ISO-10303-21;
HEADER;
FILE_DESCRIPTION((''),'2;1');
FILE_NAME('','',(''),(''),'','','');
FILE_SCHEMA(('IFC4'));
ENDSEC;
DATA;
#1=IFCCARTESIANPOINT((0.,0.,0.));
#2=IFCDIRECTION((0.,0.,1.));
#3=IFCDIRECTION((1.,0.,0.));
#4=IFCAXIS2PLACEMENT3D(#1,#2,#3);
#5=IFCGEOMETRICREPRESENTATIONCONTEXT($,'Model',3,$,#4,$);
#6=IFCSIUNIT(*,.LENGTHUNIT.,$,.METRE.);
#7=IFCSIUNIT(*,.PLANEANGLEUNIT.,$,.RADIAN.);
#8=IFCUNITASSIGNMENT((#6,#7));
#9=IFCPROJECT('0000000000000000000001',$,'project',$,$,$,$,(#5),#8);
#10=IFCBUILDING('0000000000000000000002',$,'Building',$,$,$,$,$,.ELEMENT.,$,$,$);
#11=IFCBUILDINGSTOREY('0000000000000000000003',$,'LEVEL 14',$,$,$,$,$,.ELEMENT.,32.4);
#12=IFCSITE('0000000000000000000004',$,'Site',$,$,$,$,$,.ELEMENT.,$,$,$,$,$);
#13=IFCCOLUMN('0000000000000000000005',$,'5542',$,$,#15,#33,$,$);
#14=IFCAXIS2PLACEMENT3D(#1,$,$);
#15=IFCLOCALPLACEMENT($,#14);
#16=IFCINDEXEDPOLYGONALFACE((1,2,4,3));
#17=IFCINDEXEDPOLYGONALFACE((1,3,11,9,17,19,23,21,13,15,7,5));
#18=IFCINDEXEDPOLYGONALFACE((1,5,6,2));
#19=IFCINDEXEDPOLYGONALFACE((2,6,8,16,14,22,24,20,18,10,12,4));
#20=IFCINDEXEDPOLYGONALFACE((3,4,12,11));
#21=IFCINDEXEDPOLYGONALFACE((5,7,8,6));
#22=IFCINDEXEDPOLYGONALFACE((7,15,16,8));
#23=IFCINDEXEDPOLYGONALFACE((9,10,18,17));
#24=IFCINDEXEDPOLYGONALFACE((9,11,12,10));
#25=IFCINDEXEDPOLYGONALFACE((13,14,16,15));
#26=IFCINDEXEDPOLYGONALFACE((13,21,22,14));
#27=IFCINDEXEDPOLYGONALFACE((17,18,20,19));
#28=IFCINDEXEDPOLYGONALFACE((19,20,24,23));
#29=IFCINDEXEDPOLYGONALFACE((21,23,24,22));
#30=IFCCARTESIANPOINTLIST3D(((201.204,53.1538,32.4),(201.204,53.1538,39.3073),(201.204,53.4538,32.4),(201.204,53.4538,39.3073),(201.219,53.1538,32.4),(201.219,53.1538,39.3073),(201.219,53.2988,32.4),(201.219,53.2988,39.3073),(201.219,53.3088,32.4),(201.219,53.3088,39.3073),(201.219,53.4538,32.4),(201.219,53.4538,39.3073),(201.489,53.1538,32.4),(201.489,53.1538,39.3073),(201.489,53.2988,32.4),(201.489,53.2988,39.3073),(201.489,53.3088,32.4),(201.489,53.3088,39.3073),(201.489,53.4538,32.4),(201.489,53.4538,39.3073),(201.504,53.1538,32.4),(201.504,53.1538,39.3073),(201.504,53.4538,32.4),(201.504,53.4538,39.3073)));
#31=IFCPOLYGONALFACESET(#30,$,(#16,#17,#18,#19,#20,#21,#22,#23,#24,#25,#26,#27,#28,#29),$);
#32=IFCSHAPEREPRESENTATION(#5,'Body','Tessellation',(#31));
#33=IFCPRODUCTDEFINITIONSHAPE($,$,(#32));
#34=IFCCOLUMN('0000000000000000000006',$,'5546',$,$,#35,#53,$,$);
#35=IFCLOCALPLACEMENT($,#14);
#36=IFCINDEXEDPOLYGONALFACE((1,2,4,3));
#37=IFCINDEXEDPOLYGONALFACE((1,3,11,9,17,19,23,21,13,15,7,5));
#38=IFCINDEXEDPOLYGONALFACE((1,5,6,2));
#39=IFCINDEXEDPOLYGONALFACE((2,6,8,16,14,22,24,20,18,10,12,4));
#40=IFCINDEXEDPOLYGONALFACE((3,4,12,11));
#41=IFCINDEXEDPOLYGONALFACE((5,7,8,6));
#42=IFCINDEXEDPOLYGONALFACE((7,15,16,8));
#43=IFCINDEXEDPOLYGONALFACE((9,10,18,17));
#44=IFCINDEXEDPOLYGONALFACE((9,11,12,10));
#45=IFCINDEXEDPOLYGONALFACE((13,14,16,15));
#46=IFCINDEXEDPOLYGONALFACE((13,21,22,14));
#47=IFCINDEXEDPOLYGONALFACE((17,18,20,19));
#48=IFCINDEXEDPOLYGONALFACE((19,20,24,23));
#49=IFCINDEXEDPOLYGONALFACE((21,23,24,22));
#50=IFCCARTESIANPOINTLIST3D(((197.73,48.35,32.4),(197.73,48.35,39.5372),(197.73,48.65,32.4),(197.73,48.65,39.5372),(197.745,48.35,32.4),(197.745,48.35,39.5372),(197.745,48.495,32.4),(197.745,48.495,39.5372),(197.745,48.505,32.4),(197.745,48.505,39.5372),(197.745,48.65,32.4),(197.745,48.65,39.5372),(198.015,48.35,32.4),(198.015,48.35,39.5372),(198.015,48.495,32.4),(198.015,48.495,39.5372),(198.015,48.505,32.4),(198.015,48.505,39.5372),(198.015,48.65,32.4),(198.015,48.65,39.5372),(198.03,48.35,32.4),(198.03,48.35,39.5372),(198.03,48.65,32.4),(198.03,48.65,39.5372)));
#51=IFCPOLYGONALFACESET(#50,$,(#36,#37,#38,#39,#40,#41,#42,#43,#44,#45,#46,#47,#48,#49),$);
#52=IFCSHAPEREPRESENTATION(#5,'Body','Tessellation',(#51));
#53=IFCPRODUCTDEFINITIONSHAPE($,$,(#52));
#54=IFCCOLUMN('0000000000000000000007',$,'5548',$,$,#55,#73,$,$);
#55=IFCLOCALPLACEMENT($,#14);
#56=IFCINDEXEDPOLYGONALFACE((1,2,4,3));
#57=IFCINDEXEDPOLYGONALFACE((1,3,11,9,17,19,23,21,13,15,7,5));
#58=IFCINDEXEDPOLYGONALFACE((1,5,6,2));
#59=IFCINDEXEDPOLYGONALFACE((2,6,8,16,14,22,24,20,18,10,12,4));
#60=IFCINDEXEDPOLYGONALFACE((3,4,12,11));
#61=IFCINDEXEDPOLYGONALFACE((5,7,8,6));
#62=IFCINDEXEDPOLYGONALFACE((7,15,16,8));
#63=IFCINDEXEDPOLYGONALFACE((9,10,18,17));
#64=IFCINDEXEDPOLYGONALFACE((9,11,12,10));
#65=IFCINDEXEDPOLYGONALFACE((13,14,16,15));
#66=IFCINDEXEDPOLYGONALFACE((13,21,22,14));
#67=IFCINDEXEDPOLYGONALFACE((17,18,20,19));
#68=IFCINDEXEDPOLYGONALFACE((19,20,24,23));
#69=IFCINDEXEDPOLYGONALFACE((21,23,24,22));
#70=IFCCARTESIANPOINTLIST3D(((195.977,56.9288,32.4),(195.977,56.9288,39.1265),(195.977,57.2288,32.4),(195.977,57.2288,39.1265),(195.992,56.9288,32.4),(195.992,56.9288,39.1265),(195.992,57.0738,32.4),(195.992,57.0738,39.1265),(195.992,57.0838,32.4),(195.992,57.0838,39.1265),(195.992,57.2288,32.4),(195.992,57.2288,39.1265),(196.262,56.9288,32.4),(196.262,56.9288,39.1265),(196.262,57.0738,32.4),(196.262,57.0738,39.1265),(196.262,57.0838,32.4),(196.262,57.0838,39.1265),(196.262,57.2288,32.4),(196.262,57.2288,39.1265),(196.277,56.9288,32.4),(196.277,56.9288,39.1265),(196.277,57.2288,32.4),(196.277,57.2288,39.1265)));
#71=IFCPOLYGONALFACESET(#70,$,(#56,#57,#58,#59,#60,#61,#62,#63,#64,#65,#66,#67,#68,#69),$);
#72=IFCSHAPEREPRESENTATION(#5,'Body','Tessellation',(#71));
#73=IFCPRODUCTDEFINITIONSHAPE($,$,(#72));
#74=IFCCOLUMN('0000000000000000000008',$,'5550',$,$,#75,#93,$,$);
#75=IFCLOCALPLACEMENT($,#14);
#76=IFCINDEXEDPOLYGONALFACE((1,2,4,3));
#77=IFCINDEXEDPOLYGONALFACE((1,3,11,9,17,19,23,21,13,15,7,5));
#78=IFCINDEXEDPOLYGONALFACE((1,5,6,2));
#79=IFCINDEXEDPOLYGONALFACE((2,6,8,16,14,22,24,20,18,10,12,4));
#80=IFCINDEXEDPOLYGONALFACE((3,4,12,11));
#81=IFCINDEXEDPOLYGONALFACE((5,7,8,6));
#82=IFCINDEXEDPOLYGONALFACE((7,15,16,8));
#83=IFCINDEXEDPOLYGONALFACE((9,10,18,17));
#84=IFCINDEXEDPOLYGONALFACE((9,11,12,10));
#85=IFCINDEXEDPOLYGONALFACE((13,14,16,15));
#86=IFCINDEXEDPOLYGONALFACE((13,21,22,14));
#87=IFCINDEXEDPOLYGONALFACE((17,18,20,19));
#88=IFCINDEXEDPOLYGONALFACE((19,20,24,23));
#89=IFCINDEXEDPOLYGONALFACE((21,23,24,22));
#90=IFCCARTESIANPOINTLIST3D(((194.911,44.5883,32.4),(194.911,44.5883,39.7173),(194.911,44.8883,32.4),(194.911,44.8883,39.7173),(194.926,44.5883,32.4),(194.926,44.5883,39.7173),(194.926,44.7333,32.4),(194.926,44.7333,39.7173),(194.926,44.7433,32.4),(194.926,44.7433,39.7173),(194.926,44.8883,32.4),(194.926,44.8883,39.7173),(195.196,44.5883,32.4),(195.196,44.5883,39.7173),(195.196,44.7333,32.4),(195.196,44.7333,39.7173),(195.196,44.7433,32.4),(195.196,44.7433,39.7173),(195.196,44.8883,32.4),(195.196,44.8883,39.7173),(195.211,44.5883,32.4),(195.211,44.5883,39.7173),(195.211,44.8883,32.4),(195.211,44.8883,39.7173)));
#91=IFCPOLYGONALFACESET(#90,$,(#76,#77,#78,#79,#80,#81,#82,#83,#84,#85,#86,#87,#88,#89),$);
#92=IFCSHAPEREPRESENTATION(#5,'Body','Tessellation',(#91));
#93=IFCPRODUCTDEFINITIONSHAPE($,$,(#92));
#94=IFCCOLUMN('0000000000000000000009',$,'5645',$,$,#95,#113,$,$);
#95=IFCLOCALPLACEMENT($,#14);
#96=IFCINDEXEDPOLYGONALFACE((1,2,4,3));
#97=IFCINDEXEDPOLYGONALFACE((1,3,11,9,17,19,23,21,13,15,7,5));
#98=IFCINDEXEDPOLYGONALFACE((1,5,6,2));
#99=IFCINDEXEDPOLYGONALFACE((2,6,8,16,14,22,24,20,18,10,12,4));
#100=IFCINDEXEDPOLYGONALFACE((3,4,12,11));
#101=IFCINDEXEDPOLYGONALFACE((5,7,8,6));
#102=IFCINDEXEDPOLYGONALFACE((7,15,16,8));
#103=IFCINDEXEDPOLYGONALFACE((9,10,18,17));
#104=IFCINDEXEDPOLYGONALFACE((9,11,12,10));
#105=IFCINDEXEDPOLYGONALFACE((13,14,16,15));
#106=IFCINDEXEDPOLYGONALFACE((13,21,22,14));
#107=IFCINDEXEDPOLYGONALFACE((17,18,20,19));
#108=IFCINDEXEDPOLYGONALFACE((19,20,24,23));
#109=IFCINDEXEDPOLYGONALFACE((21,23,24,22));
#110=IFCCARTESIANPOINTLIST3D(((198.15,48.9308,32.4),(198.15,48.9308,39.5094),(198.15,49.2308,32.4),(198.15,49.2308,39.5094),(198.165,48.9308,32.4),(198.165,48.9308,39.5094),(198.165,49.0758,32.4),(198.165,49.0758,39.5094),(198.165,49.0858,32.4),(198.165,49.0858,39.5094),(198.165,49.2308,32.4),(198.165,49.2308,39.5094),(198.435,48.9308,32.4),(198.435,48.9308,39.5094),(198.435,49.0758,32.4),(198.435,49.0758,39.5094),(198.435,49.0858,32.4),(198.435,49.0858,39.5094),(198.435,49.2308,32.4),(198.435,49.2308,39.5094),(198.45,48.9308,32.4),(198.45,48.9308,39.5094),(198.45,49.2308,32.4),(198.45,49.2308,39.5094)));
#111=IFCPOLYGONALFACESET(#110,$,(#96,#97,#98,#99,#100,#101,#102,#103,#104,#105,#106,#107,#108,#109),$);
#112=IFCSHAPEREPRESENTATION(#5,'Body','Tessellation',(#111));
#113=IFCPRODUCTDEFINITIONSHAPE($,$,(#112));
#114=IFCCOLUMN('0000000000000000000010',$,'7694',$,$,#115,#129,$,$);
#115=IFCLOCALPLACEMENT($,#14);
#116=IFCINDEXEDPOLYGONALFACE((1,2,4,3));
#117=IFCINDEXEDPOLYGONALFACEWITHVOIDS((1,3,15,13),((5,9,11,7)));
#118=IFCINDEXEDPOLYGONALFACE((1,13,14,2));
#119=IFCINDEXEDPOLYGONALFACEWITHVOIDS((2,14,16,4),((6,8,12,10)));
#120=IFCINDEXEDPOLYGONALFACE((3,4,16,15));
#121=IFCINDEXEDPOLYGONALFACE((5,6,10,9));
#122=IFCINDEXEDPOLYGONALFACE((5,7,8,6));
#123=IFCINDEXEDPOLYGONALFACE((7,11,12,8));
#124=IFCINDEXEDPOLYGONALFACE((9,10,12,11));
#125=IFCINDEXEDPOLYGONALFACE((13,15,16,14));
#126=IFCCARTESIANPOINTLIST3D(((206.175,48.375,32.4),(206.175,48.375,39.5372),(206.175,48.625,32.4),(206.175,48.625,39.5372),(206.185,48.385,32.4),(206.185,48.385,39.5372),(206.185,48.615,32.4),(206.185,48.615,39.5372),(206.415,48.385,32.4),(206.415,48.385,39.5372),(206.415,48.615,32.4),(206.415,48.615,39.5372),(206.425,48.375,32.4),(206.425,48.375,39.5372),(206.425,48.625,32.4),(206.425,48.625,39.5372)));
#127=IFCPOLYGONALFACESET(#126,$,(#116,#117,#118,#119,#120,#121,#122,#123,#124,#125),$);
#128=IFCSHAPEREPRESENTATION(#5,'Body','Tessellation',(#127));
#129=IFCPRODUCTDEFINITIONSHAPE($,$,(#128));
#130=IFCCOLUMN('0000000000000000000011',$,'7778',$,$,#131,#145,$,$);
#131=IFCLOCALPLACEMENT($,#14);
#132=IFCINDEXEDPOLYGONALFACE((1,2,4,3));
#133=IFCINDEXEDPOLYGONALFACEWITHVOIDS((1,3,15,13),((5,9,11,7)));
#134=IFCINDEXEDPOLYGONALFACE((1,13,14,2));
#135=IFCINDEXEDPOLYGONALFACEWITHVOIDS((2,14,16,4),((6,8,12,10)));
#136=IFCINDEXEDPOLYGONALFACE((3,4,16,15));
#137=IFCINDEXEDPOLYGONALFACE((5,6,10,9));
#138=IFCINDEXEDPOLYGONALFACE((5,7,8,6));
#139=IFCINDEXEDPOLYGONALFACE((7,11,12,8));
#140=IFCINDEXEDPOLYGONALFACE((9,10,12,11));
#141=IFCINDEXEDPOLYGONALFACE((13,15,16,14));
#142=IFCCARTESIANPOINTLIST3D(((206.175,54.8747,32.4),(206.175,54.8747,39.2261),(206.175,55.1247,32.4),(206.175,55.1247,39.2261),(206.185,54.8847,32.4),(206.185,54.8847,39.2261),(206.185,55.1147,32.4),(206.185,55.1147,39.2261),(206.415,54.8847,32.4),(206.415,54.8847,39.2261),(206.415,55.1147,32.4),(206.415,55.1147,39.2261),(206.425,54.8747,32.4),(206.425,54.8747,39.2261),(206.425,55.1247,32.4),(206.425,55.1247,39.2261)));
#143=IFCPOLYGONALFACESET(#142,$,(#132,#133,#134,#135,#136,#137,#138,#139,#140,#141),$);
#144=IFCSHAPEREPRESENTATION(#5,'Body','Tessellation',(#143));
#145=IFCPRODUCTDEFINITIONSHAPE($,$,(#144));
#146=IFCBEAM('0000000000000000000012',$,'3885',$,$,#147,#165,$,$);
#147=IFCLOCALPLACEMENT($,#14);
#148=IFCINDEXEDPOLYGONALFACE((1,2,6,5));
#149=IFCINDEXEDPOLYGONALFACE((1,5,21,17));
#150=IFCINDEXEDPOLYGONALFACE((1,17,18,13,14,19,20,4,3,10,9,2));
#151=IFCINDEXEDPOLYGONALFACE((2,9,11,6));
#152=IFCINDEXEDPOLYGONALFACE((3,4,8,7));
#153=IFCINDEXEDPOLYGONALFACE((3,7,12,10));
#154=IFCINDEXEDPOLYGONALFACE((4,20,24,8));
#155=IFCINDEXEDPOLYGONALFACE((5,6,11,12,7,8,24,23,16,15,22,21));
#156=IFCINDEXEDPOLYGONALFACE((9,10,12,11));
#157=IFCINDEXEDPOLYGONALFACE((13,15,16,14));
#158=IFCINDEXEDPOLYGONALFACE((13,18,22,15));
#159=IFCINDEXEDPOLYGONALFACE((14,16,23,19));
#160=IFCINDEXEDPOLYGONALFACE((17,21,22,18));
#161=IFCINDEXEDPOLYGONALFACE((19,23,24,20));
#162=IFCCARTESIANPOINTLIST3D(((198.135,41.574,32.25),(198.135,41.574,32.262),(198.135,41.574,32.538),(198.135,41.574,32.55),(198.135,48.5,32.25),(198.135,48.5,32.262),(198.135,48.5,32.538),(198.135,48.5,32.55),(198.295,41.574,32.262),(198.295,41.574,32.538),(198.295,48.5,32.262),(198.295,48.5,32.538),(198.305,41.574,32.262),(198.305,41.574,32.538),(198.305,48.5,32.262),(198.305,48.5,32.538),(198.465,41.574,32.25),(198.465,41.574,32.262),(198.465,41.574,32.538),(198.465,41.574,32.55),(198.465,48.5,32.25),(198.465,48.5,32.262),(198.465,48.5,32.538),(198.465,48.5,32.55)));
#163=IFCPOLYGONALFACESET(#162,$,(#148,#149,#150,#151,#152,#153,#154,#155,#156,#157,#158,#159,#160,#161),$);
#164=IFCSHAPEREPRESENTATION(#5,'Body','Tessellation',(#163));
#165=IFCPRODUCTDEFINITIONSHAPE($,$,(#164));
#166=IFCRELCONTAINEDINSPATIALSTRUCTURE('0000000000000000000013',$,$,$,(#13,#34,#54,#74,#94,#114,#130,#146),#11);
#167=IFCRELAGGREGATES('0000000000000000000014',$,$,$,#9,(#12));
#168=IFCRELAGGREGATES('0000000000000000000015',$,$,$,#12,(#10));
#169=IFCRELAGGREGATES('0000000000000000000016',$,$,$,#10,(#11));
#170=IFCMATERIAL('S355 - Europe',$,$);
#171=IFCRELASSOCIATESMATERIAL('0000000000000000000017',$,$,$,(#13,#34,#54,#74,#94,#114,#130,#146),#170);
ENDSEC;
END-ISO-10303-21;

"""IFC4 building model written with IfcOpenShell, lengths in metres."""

from ifc_helpers import new_model, si_unit, frame, origin_with_axes, origin_2d_with_axis, place, context, project, spatial, hollow_rectangle, i_section, extrude, material, material_profile, profile_set, profile_usage, element, save


model = new_model("IFC4")

# Units and contexts
model_context = context("Model", 3, world=origin_with_axes())
ifc_project = project(units=[si_unit("LENGTHUNIT", "METRE"), si_unit("PLANEANGLEUNIT", "RADIAN")], contexts=[model_context])

# Site, building, storey
site = spatial("IfcSite", under=ifc_project, Name="Site", CompositionType="ELEMENT")
building = spatial("IfcBuilding", under=site, Name="Building", CompositionType="ELEMENT")
storey = spatial("IfcBuildingStorey", under=building, Name="LEVEL 14", CompositionType="ELEMENT", Elevation=32.4)

# Columns
ifc_material = material(Name="S355 - Europe")
ifc_material_profile_1 = material_profile(ifc_material, i_section(OverallWidth=0.3, OverallDepth=0.3, WebThickness=0.01, FlangeThickness=0.015, at=origin_2d_with_axis()))
ifc_profile_set_1 = profile_set([ifc_material_profile_1])
ifc_profile_usage_1 = profile_usage(ifc_profile_set_1, cardinal=10)
column_1_placement = place(None, frame((201.354, 53.3038, 32.4), z_axis=(0.0, 0.0, 1.0), x_axis=(0.0, -1.0, 0.0)))
element("IfcColumn", 1, at=column_1_placement, inside=storey, material=ifc_profile_usage_1, Name="5542", context=model_context, shape_type="SweptSolid", body=[
    extrude(i_section(OverallWidth=0.3, OverallDepth=0.3, WebThickness=0.01, FlangeThickness=0.015, at=origin_2d_with_axis()), origin_with_axes(), (0.0, 0.0, 1.0), 6.9073),
])
ifc_material_profile_2 = material_profile(ifc_material, i_section(OverallWidth=0.3, OverallDepth=0.3, WebThickness=0.01, FlangeThickness=0.015, at=origin_2d_with_axis()))
ifc_profile_set_2 = profile_set([ifc_material_profile_2])
ifc_profile_usage_2 = profile_usage(ifc_profile_set_2, cardinal=10)
column_2_placement = place(None, frame((197.88, 48.5, 32.4), z_axis=(0.0, 0.0, 1.0), x_axis=(0.0, -1.0, 0.0)))
element("IfcColumn", 2, at=column_2_placement, inside=storey, material=ifc_profile_usage_2, Name="5546", context=model_context, shape_type="SweptSolid", body=[
    extrude(i_section(OverallWidth=0.3, OverallDepth=0.3, WebThickness=0.01, FlangeThickness=0.015, at=origin_2d_with_axis()), origin_with_axes(), (0.0, 0.0, 1.0), 7.1372),
])
ifc_material_profile_3 = material_profile(ifc_material, i_section(OverallWidth=0.3, OverallDepth=0.3, WebThickness=0.01, FlangeThickness=0.015, at=origin_2d_with_axis()))
ifc_profile_set_3 = profile_set([ifc_material_profile_3])
ifc_profile_usage_3 = profile_usage(ifc_profile_set_3, cardinal=10)
column_3_placement = place(None, frame((196.127, 57.0788, 32.4), z_axis=(0.0, 0.0, 1.0), x_axis=(0.0, -1.0, 0.0)))
element("IfcColumn", 3, at=column_3_placement, inside=storey, material=ifc_profile_usage_3, Name="5548", context=model_context, shape_type="SweptSolid", body=[
    extrude(i_section(OverallWidth=0.3, OverallDepth=0.3, WebThickness=0.01, FlangeThickness=0.015, at=origin_2d_with_axis()), origin_with_axes(), (0.0, 0.0, 1.0), 6.7265),
])
ifc_material_profile_4 = material_profile(ifc_material, i_section(OverallWidth=0.3, OverallDepth=0.3, WebThickness=0.01, FlangeThickness=0.015, at=origin_2d_with_axis()))
ifc_profile_set_4 = profile_set([ifc_material_profile_4])
ifc_profile_usage_4 = profile_usage(ifc_profile_set_4, cardinal=10)
column_4_placement = place(None, frame((195.061, 44.7383, 32.4), z_axis=(0.0, 0.0, 1.0), x_axis=(0.0, -1.0, 0.0)))
element("IfcColumn", 4, at=column_4_placement, inside=storey, material=ifc_profile_usage_4, Name="5550", context=model_context, shape_type="SweptSolid", body=[
    extrude(i_section(OverallWidth=0.3, OverallDepth=0.3, WebThickness=0.01, FlangeThickness=0.015, at=origin_2d_with_axis()), origin_with_axes(), (0.0, 0.0, 1.0), 7.3173),
])
ifc_material_profile_5 = material_profile(ifc_material, i_section(OverallWidth=0.3, OverallDepth=0.3, WebThickness=0.01, FlangeThickness=0.015, at=origin_2d_with_axis()))
ifc_profile_set_5 = profile_set([ifc_material_profile_5])
ifc_profile_usage_5 = profile_usage(ifc_profile_set_5, cardinal=10)
column_5_placement = place(None, frame((198.3, 49.0808, 39.5094), z_axis=(0.0, 0.0, -1.0), x_axis=(0.0, 1.0, 0.0)))
element("IfcColumn", 5, at=column_5_placement, inside=storey, material=ifc_profile_usage_5, Name="5645", context=model_context, shape_type="SweptSolid", body=[
    extrude(i_section(OverallWidth=0.3, OverallDepth=0.3, WebThickness=0.01, FlangeThickness=0.015, at=origin_2d_with_axis()), origin_with_axes(), (0.0, 0.0, 1.0), 7.1094),
])
ifc_material_profile_6 = material_profile(ifc_material, hollow_rectangle(XDim=0.25, YDim=0.25, WallThickness=0.01, at=origin_2d_with_axis()))
ifc_profile_set_6 = profile_set([ifc_material_profile_6])
ifc_profile_usage_6 = profile_usage(ifc_profile_set_6, cardinal=10)
column_6_placement = place(None, frame((206.3, 48.5, 32.4), z_axis=(0.0, 0.0, 1.0), x_axis=(0.0, -1.0, 0.0)))
element("IfcColumn", 6, at=column_6_placement, inside=storey, material=ifc_profile_usage_6, Name="7694", context=model_context, shape_type="SweptSolid", body=[
    extrude(hollow_rectangle(XDim=0.25, YDim=0.25, WallThickness=0.01, at=origin_2d_with_axis()), origin_with_axes(), (0.0, 0.0, 1.0), 7.1372),
])
ifc_material_profile_7 = material_profile(ifc_material, hollow_rectangle(XDim=0.25, YDim=0.25, WallThickness=0.01, at=origin_2d_with_axis()))
ifc_profile_set_7 = profile_set([ifc_material_profile_7])
ifc_profile_usage_7 = profile_usage(ifc_profile_set_7, cardinal=10)
column_7_placement = place(None, frame((206.3, 54.9997, 32.4), z_axis=(0.0, 0.0, 1.0), x_axis=(0.0, -1.0, 0.0)))
element("IfcColumn", 7, at=column_7_placement, inside=storey, material=ifc_profile_usage_7, Name="7778", context=model_context, shape_type="SweptSolid", body=[
    extrude(hollow_rectangle(XDim=0.25, YDim=0.25, WallThickness=0.01, at=origin_2d_with_axis()), origin_with_axes(), (0.0, 0.0, 1.0), 6.8261),
])

# Beam
ifc_material_profile_8 = material_profile(ifc_material, i_section(OverallWidth=0.33, OverallDepth=0.3, WebThickness=0.01, FlangeThickness=0.012, at=origin_2d_with_axis()))
ifc_profile_set_8 = profile_set([ifc_material_profile_8])
ifc_profile_usage_8 = profile_usage(ifc_profile_set_8, cardinal=10)
beam_1_placement = place(None, frame((198.3, 48.5, 32.4), z_axis=(0.0, -1.0, 0.0), x_axis=(1.0, 0.0, 0.0)))
element("IfcBeam", 8, at=beam_1_placement, inside=storey, material=ifc_profile_usage_8, Name="3885", context=model_context, shape_type="SweptSolid", body=[
    extrude(i_section(OverallWidth=0.33, OverallDepth=0.3, WebThickness=0.01, FlangeThickness=0.012, at=origin_2d_with_axis()), origin_with_axes(), (0.0, 0.0, 1.0), 6.926),
])

save(model, "model.ifc")
